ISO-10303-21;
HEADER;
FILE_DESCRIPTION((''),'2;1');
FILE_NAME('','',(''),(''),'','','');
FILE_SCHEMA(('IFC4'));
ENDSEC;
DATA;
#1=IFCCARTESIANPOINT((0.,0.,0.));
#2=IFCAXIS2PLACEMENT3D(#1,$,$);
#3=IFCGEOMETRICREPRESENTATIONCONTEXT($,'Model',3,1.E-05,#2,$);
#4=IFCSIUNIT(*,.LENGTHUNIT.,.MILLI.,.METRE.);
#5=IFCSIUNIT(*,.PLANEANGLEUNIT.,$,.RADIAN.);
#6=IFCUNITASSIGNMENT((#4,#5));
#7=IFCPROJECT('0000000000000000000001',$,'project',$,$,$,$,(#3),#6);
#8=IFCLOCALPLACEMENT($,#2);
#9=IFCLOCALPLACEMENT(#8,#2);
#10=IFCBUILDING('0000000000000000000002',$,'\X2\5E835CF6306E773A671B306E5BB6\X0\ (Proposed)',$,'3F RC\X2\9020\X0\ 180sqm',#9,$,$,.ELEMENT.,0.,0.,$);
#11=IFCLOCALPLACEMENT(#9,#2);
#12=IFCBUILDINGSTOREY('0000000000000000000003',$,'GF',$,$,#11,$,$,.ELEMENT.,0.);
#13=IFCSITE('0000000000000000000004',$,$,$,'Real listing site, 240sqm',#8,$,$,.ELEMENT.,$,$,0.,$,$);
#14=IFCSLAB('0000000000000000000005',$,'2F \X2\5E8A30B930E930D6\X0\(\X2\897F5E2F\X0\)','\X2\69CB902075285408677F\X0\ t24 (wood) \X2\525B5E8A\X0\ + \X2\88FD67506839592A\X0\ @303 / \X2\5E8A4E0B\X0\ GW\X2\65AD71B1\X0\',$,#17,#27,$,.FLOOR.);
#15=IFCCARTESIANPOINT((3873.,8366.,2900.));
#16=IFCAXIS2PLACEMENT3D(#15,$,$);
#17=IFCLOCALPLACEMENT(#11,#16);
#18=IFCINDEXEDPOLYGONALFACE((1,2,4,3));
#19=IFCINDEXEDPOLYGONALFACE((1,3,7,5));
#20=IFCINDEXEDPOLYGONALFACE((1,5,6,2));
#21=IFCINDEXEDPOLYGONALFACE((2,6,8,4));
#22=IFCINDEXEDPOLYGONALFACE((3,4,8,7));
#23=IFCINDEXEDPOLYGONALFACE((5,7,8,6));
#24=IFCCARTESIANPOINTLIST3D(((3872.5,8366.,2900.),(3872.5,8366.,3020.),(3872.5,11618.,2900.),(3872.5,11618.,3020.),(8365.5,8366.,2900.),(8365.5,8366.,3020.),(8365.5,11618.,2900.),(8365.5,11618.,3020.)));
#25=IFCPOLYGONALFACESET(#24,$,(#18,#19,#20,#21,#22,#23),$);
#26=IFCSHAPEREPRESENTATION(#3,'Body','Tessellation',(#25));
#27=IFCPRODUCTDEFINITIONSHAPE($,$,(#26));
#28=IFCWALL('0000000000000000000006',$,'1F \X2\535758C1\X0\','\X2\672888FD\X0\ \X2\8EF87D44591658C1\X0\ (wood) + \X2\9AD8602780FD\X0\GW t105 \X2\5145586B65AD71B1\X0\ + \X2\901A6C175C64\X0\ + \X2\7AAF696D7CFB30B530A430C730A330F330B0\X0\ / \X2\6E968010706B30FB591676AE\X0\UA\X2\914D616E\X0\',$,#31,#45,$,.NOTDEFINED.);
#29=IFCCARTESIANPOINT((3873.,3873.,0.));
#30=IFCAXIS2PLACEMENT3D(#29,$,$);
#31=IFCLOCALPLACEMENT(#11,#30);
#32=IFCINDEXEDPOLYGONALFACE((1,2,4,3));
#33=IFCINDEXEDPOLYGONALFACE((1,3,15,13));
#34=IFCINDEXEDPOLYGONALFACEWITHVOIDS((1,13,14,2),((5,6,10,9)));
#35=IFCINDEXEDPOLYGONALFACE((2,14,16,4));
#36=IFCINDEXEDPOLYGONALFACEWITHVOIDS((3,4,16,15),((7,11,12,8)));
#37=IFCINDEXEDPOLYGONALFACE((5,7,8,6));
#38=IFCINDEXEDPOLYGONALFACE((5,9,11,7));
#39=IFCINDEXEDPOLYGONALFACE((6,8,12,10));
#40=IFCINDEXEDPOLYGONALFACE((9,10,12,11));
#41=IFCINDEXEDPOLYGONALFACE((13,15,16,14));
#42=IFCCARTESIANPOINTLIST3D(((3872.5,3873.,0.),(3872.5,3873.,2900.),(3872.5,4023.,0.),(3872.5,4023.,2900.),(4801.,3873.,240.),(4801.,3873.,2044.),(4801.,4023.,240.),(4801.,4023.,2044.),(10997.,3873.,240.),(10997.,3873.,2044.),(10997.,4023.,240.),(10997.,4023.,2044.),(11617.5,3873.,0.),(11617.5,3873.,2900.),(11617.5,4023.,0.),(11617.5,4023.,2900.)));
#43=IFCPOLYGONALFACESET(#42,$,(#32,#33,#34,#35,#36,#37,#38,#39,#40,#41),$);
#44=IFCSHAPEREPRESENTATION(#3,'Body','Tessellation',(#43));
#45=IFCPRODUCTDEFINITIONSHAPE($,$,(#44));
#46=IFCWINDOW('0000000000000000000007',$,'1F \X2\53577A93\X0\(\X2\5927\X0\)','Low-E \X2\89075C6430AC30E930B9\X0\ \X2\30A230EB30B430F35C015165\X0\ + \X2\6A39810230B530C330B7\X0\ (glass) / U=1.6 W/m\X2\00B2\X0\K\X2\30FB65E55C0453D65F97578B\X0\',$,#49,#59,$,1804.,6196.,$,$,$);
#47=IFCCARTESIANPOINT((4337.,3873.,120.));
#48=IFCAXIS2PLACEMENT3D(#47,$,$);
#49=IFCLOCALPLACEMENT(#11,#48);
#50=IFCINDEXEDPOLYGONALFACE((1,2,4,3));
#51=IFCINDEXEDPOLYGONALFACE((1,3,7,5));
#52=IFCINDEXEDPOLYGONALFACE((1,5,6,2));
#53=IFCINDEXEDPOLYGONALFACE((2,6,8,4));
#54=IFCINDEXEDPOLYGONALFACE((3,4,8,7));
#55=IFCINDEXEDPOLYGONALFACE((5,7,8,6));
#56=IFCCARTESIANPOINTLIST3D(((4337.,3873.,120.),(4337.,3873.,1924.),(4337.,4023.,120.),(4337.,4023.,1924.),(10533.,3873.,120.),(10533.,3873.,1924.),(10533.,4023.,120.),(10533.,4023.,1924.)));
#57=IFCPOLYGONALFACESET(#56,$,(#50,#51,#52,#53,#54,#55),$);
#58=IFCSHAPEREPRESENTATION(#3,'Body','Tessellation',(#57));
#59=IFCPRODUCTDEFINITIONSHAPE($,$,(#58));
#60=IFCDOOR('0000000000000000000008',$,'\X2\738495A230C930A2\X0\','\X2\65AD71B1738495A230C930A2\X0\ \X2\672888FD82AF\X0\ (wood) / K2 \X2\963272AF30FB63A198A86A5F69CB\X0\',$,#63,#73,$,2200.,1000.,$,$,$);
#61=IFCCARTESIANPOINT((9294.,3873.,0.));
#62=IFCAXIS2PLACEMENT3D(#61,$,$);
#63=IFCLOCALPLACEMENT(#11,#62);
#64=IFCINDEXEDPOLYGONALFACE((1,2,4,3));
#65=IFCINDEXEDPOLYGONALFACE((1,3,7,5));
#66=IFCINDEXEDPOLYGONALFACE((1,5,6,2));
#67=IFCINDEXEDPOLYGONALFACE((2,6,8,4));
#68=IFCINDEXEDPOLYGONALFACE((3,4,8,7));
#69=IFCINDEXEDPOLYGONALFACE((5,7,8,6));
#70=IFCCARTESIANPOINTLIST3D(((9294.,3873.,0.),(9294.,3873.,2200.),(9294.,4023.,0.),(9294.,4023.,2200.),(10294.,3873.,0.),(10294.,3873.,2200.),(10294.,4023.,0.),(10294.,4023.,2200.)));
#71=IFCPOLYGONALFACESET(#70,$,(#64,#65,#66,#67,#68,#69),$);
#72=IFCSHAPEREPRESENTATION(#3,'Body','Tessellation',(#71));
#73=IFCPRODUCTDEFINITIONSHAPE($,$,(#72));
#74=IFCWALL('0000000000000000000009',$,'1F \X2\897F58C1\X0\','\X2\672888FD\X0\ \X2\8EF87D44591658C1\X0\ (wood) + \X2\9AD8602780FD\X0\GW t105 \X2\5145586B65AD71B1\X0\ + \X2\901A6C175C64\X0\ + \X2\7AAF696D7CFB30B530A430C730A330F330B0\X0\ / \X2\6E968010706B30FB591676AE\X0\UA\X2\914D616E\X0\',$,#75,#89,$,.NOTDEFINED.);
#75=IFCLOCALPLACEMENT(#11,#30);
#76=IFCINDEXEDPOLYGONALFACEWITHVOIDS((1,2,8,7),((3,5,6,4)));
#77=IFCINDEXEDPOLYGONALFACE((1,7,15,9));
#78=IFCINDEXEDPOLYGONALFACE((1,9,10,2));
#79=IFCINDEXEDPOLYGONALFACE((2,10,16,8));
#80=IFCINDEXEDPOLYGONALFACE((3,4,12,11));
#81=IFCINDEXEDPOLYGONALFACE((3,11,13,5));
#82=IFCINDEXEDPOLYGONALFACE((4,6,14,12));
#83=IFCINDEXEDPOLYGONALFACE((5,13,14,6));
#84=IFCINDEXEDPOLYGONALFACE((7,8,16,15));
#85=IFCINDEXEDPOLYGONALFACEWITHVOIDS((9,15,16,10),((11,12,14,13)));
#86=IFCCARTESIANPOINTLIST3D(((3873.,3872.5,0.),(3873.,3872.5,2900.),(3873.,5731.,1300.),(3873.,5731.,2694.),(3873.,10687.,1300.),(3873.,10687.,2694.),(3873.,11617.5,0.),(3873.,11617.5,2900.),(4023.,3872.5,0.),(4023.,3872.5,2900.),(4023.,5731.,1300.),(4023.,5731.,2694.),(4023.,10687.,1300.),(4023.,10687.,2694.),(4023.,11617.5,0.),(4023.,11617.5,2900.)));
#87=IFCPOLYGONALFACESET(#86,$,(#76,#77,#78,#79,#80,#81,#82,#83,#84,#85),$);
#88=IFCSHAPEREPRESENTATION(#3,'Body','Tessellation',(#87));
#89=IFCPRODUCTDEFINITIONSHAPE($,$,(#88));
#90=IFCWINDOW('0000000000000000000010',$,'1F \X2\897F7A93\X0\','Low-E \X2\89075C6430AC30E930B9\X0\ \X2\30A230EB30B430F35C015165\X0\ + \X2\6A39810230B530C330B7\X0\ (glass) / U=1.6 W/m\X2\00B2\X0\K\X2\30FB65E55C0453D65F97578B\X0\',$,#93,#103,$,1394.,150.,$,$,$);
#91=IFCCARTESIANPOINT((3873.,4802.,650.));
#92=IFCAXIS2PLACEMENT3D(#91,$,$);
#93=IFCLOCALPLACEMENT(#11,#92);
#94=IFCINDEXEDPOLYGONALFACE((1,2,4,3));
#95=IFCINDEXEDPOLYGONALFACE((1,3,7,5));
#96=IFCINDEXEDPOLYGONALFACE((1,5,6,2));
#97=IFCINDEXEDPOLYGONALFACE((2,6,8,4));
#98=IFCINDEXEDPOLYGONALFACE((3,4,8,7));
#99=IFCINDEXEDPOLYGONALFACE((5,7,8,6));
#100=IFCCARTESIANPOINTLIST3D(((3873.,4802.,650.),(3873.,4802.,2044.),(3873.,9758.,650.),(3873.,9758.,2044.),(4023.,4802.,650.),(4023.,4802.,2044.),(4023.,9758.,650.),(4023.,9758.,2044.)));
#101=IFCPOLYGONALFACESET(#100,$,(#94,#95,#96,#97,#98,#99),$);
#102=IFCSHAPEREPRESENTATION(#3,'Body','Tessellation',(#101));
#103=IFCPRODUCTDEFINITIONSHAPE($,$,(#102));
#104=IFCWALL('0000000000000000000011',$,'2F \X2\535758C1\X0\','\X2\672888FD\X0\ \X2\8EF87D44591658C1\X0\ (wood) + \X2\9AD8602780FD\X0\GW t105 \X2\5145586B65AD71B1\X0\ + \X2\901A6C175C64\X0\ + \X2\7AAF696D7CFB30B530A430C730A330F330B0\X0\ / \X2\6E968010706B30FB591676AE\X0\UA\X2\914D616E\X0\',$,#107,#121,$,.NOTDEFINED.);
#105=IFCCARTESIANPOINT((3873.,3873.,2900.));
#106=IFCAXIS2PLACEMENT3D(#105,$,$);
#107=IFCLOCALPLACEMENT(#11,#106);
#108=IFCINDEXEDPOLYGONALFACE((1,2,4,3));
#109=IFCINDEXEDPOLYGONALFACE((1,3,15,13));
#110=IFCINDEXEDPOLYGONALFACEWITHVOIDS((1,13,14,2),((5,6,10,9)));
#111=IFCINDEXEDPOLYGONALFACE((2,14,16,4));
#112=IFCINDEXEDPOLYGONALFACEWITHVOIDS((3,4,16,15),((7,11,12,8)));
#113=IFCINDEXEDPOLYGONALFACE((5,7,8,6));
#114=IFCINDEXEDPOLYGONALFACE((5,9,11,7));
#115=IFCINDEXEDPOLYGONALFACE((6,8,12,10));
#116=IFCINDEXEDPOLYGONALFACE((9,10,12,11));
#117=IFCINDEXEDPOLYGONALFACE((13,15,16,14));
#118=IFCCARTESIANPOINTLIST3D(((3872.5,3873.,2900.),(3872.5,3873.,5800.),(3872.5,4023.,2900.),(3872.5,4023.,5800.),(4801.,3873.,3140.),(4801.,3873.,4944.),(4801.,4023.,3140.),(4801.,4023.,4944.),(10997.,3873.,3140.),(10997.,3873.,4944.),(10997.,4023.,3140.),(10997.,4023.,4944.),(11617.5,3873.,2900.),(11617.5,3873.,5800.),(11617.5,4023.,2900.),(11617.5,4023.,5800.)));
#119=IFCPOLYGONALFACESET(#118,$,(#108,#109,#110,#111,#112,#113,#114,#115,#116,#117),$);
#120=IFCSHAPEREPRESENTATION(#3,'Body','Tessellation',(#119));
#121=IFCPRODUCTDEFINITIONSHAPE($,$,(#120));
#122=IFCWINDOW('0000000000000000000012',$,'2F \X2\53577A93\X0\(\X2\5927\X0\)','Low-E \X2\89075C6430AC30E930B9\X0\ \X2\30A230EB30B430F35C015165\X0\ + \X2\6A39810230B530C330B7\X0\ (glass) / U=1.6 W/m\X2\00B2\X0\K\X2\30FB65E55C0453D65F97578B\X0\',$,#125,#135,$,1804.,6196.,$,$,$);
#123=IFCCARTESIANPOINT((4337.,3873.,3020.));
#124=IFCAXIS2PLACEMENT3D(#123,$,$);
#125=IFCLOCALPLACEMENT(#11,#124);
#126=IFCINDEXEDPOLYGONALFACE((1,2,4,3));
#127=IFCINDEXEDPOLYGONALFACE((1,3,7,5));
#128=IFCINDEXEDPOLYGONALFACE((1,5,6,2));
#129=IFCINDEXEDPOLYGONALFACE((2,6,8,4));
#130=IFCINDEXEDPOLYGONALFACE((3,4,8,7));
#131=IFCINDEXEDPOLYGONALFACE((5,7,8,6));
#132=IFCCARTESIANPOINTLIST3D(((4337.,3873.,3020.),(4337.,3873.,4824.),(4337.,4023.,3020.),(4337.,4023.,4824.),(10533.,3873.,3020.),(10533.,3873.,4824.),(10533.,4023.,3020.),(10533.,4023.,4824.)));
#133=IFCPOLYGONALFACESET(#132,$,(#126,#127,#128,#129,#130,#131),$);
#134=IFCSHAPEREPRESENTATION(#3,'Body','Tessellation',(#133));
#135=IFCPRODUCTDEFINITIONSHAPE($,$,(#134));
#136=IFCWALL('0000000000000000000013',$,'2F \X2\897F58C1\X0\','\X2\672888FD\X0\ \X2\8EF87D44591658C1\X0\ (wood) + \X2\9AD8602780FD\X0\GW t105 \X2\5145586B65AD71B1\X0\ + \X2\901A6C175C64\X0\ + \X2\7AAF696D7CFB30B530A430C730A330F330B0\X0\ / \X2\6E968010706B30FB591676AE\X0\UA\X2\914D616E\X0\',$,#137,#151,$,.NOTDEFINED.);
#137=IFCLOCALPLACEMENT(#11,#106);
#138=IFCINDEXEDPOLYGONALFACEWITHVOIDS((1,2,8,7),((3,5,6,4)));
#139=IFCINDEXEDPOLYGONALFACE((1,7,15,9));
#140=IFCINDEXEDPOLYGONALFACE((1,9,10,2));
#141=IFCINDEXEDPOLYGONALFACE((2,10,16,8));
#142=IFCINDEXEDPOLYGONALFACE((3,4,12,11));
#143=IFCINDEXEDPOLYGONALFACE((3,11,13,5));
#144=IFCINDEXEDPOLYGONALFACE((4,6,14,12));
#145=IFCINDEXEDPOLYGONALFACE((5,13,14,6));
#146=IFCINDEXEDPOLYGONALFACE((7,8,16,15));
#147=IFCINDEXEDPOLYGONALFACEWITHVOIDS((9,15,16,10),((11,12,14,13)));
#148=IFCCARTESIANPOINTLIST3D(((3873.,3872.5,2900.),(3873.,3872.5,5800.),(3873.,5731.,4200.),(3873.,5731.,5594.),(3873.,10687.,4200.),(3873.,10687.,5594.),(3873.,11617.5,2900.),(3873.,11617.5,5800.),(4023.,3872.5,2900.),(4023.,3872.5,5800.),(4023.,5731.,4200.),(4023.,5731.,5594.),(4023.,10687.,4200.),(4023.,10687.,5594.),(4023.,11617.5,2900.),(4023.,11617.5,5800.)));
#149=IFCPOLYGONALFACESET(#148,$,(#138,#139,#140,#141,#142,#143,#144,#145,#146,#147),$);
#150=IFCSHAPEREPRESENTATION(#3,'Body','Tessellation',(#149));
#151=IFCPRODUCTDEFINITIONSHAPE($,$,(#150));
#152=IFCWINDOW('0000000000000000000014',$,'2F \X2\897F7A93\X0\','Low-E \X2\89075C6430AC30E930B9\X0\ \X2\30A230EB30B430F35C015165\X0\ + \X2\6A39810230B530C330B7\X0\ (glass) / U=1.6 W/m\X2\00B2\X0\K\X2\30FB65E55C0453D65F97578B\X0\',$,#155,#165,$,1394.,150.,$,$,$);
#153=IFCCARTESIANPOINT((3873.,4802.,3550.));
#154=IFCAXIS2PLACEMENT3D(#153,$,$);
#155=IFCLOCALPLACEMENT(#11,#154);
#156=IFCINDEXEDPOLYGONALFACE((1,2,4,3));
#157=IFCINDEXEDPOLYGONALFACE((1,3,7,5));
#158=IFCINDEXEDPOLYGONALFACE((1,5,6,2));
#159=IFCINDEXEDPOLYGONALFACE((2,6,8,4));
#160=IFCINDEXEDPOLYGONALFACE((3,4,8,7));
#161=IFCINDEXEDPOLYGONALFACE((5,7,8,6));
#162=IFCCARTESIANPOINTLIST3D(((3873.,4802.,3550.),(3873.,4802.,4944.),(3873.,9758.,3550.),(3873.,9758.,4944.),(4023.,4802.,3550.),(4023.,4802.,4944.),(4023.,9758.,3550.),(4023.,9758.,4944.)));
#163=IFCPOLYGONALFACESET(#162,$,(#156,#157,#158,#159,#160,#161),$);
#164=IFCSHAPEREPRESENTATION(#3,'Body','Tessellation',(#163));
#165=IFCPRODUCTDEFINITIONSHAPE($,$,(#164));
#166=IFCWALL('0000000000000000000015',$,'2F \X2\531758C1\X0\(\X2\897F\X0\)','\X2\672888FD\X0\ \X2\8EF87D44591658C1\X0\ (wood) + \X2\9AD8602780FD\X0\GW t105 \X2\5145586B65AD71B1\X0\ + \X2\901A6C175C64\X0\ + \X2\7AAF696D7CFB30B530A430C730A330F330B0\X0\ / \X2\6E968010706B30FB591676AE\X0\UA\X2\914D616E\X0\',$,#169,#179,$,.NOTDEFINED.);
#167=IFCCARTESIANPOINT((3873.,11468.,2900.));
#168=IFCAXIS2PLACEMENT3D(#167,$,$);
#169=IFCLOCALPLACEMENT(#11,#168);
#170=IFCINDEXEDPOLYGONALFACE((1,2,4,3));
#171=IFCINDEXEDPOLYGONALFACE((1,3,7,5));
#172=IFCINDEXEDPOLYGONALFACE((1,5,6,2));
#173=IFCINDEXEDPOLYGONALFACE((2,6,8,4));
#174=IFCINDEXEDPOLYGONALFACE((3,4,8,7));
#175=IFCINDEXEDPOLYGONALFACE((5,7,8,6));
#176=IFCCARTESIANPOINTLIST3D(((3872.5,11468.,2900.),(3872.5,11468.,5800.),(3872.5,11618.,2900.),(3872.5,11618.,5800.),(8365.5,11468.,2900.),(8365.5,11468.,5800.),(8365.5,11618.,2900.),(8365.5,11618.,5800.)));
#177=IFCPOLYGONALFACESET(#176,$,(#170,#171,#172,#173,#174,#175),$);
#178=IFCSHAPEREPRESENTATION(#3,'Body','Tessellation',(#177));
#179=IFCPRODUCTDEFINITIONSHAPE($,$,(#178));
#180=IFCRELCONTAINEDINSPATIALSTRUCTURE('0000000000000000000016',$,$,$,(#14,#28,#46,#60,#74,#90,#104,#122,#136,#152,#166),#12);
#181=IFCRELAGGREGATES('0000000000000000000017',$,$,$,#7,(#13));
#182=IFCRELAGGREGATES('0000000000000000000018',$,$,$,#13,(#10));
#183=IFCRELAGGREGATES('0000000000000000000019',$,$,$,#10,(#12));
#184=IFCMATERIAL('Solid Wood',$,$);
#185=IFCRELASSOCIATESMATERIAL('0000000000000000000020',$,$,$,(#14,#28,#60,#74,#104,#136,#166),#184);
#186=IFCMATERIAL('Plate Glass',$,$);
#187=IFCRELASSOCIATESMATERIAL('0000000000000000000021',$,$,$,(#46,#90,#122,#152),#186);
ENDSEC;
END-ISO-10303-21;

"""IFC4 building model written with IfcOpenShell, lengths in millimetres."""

from ifc_helpers import new_model, si_unit, frame, frame_2d, origin, place, context, project, spatial, rectangle, extrude, material, element, fill, save


model = new_model("IFC4")

# Units and contexts
model_context = context("Model", 3, precision=1e-05, world=origin())
ifc_project = project(units=[si_unit("LENGTHUNIT", "METRE", prefix="MILLI"), si_unit("PLANEANGLEUNIT", "RADIAN")], contexts=[model_context])

# Site, building, storey
site_placement = place(None, origin())
site = spatial("IfcSite", under=ifc_project, at=site_placement, ObjectType="Real listing site, 240sqm", CompositionType="ELEMENT", RefElevation=0.0)
building_placement = place(site_placement, origin())
building = spatial("IfcBuilding", under=site, at=building_placement, Name="広島の眺望の家 (Proposed)", ObjectType="3F RC造 180sqm", CompositionType="ELEMENT", ElevationOfRefHeight=0.0, ElevationOfTerrain=0.0)
storey_placement = place(building_placement, origin())
storey = spatial("IfcBuildingStorey", under=building, at=storey_placement, Name="GF", CompositionType="ELEMENT", Elevation=0.0)

# Slab
ifc_material_1 = material(Name="Solid Wood")
slab_1_placement = place(storey_placement, frame((3873.0, 8366.0, 2900.0)))
element("IfcSlab", 1, at=slab_1_placement, inside=storey, material=ifc_material_1, Name="2F 床スラブ(西帯)", Description="構造用合板 t24 (wood) 剛床 + 製材根太 @303 / 床下 GW断熱", PredefinedType="FLOOR", context=model_context, shape_type="SweptSolid", body=[
    extrude(rectangle(XDim=4493.0, YDim=3252.0, at=frame_2d((2246.0, 1626.0))), frame((3873.0, 8366.0, 2900.0)), (0.0, 0.0, 1.0), 120.0),
])

# Wall, openings, window, door
wall_1_placement = place(storey_placement, frame((3873.0, 3873.0, 0.0)))
wall_1 = element("IfcWall", 2, at=wall_1_placement, inside=storey, material=ifc_material_1, Name="1F 南壁", Description="木製 軸組外壁 (wood) + 高性能GW t105 充填断熱 + 通気層 + 窯業系サイディング / 準耐火・外皮UA配慮", PredefinedType="NOTDEFINED", context=model_context, shape_type="SweptSolid", body=[
    extrude(rectangle(XDim=7745.0, YDim=150.0, at=frame_2d((3872.0, 75.0))), frame((3873.0, 3873.0, 0.0)), (0.0, 0.0, 1.0), 2900.0),
])
opening_1_placement = place(storey_placement, frame((4337.0, 3873.0, 120.0)))
opening_1 = element("IfcOpeningElement", 3, at=opening_1_placement, cuts=wall_1, PredefinedType="NOTDEFINED", context=model_context, shape_type="SweptSolid", body=[
    extrude(rectangle(XDim=6196.0, YDim=150.0, at=frame_2d((3098.0, 75.0))), frame((4337.0, 3873.0, 120.0)), (0.0, 0.0, 1.0), 1804.0),
])
opening_2_placement = place(storey_placement, frame((9294.0, 3873.0, 0.0)))
opening_2 = element("IfcOpeningElement", 4, at=opening_2_placement, cuts=wall_1, PredefinedType="NOTDEFINED", context=model_context, shape_type="SweptSolid", body=[
    extrude(rectangle(XDim=1000.0, YDim=150.0, at=frame_2d((500.0, 75.0))), frame((9294.0, 3873.0, 0.0)), (0.0, 0.0, 1.0), 2200.0),
])
ifc_material_2 = material(Name="Plate Glass")
window_1_placement = place(storey_placement, frame((4337.0, 3873.0, 120.0)))
window_1 = element("IfcWindow", 5, at=window_1_placement, inside=storey, material=ifc_material_2, Name="1F 南窓(大)", Description="Low-E 複層ガラス アルゴン封入 + 樹脂サッシ (glass) / U=1.6 W/m²K・日射取得型", OverallHeight=1804.0, OverallWidth=6196.0, context=model_context, shape_type="SweptSolid", body=[
    extrude(rectangle(XDim=6196.0, YDim=150.0, at=frame_2d((3098.0, 75.0))), frame((4337.0, 3873.0, 120.0)), (0.0, 0.0, 1.0), 1804.0),
])
fill(opening_1, window_1)
door_placement = place(storey_placement, frame((9294.0, 3873.0, 0.0)))
door = element("IfcDoor", 6, at=door_placement, inside=storey, material=ifc_material_1, Name="玄関ドア", Description="断熱玄関ドア 木製芯 (wood) / K2 防犯・採風機構", OverallHeight=2200.0, OverallWidth=1000.0, context=model_context, shape_type="SweptSolid", body=[
    extrude(rectangle(XDim=1000.0, YDim=150.0, at=frame_2d((500.0, 75.0))), frame((9294.0, 3873.0, 0.0)), (0.0, 0.0, 1.0), 2200.0),
])
fill(opening_2, door)

# Wall, opening, window
wall_2_placement = place(storey_placement, frame((3873.0, 3873.0, 0.0)))
wall_2 = element("IfcWall", 7, at=wall_2_placement, inside=storey, material=ifc_material_1, Name="1F 西壁", Description="木製 軸組外壁 (wood) + 高性能GW t105 充填断熱 + 通気層 + 窯業系サイディング / 準耐火・外皮UA配慮", PredefinedType="NOTDEFINED", context=model_context, shape_type="SweptSolid", body=[
    extrude(rectangle(XDim=150.0, YDim=7745.0, at=frame_2d((75.0, 3872.0))), frame((3873.0, 3873.0, 0.0)), (0.0, 0.0, 1.0), 2900.0),
])
opening_3_placement = place(storey_placement, frame((3873.0, 4802.0, 650.0)))
opening_3 = element("IfcOpeningElement", 8, at=opening_3_placement, cuts=wall_2, PredefinedType="NOTDEFINED", context=model_context, shape_type="SweptSolid", body=[
    extrude(rectangle(XDim=150.0, YDim=4956.0, at=frame_2d((75.0, 2478.0))), frame((3873.0, 4802.0, 650.0)), (0.0, 0.0, 1.0), 1394.0),
])
window_2_placement = place(storey_placement, frame((3873.0, 4802.0, 650.0)))
window_2 = element("IfcWindow", 9, at=window_2_placement, inside=storey, material=ifc_material_2, Name="1F 西窓", Description="Low-E 複層ガラス アルゴン封入 + 樹脂サッシ (glass) / U=1.6 W/m²K・日射取得型", OverallHeight=1394.0, OverallWidth=150.0, context=model_context, shape_type="SweptSolid", body=[
    extrude(rectangle(XDim=150.0, YDim=4956.0, at=frame_2d((75.0, 2478.0))), frame((3873.0, 4802.0, 650.0)), (0.0, 0.0, 1.0), 1394.0),
])
fill(opening_3, window_2)

# Walls, openings, windows
wall_3_placement = place(storey_placement, frame((3873.0, 3873.0, 2900.0)))
wall_3 = element("IfcWall", 10, at=wall_3_placement, inside=storey, material=ifc_material_1, Name="2F 南壁", Description="木製 軸組外壁 (wood) + 高性能GW t105 充填断熱 + 通気層 + 窯業系サイディング / 準耐火・外皮UA配慮", PredefinedType="NOTDEFINED", context=model_context, shape_type="SweptSolid", body=[
    extrude(rectangle(XDim=7745.0, YDim=150.0, at=frame_2d((3872.0, 75.0))), frame((3873.0, 3873.0, 2900.0)), (0.0, 0.0, 1.0), 2900.0),
])
opening_4_placement = place(storey_placement, frame((4337.0, 3873.0, 3020.0)))
opening_4 = element("IfcOpeningElement", 11, at=opening_4_placement, cuts=wall_3, PredefinedType="NOTDEFINED", context=model_context, shape_type="SweptSolid", body=[
    extrude(rectangle(XDim=6196.0, YDim=150.0, at=frame_2d((3098.0, 75.0))), frame((4337.0, 3873.0, 3020.0)), (0.0, 0.0, 1.0), 1804.0),
])
window_3_placement = place(storey_placement, frame((4337.0, 3873.0, 3020.0)))
window_3 = element("IfcWindow", 12, at=window_3_placement, inside=storey, material=ifc_material_2, Name="2F 南窓(大)", Description="Low-E 複層ガラス アルゴン封入 + 樹脂サッシ (glass) / U=1.6 W/m²K・日射取得型", OverallHeight=1804.0, OverallWidth=6196.0, context=model_context, shape_type="SweptSolid", body=[
    extrude(rectangle(XDim=6196.0, YDim=150.0, at=frame_2d((3098.0, 75.0))), frame((4337.0, 3873.0, 3020.0)), (0.0, 0.0, 1.0), 1804.0),
])
fill(opening_4, window_3)
wall_4_placement = place(storey_placement, frame((3873.0, 3873.0, 2900.0)))
wall_4 = element("IfcWall", 13, at=wall_4_placement, inside=storey, material=ifc_material_1, Name="2F 西壁", Description="木製 軸組外壁 (wood) + 高性能GW t105 充填断熱 + 通気層 + 窯業系サイディング / 準耐火・外皮UA配慮", PredefinedType="NOTDEFINED", context=model_context, shape_type="SweptSolid", body=[
    extrude(rectangle(XDim=150.0, YDim=7745.0, at=frame_2d((75.0, 3872.0))), frame((3873.0, 3873.0, 2900.0)), (0.0, 0.0, 1.0), 2900.0),
])
opening_5_placement = place(storey_placement, frame((3873.0, 4802.0, 3550.0)))
opening_5 = element("IfcOpeningElement", 14, at=opening_5_placement, cuts=wall_4, PredefinedType="NOTDEFINED", context=model_context, shape_type="SweptSolid", body=[
    extrude(rectangle(XDim=150.0, YDim=4956.0, at=frame_2d((75.0, 2478.0))), frame((3873.0, 4802.0, 3550.0)), (0.0, 0.0, 1.0), 1394.0),
])
window_4_placement = place(storey_placement, frame((3873.0, 4802.0, 3550.0)))
window_4 = element("IfcWindow", 15, at=window_4_placement, inside=storey, material=ifc_material_2, Name="2F 西窓", Description="Low-E 複層ガラス アルゴン封入 + 樹脂サッシ (glass) / U=1.6 W/m²K・日射取得型", OverallHeight=1394.0, OverallWidth=150.0, context=model_context, shape_type="SweptSolid", body=[
    extrude(rectangle(XDim=150.0, YDim=4956.0, at=frame_2d((75.0, 2478.0))), frame((3873.0, 4802.0, 3550.0)), (0.0, 0.0, 1.0), 1394.0),
])
fill(opening_5, window_4)

# Wall
wall_5_placement = place(storey_placement, frame((3873.0, 11468.0, 2900.0)))
element("IfcWall", 16, at=wall_5_placement, inside=storey, material=ifc_material_1, Name="2F 北壁(西)", Description="木製 軸組外壁 (wood) + 高性能GW t105 充填断熱 + 通気層 + 窯業系サイディング / 準耐火・外皮UA配慮", PredefinedType="NOTDEFINED", context=model_context, shape_type="SweptSolid", body=[
    extrude(rectangle(XDim=4493.0, YDim=150.0, at=frame_2d((2246.0, 75.0))), frame((3873.0, 11468.0, 2900.0)), (0.0, 0.0, 1.0), 2900.0),
])

save(model, "model.ifc")
